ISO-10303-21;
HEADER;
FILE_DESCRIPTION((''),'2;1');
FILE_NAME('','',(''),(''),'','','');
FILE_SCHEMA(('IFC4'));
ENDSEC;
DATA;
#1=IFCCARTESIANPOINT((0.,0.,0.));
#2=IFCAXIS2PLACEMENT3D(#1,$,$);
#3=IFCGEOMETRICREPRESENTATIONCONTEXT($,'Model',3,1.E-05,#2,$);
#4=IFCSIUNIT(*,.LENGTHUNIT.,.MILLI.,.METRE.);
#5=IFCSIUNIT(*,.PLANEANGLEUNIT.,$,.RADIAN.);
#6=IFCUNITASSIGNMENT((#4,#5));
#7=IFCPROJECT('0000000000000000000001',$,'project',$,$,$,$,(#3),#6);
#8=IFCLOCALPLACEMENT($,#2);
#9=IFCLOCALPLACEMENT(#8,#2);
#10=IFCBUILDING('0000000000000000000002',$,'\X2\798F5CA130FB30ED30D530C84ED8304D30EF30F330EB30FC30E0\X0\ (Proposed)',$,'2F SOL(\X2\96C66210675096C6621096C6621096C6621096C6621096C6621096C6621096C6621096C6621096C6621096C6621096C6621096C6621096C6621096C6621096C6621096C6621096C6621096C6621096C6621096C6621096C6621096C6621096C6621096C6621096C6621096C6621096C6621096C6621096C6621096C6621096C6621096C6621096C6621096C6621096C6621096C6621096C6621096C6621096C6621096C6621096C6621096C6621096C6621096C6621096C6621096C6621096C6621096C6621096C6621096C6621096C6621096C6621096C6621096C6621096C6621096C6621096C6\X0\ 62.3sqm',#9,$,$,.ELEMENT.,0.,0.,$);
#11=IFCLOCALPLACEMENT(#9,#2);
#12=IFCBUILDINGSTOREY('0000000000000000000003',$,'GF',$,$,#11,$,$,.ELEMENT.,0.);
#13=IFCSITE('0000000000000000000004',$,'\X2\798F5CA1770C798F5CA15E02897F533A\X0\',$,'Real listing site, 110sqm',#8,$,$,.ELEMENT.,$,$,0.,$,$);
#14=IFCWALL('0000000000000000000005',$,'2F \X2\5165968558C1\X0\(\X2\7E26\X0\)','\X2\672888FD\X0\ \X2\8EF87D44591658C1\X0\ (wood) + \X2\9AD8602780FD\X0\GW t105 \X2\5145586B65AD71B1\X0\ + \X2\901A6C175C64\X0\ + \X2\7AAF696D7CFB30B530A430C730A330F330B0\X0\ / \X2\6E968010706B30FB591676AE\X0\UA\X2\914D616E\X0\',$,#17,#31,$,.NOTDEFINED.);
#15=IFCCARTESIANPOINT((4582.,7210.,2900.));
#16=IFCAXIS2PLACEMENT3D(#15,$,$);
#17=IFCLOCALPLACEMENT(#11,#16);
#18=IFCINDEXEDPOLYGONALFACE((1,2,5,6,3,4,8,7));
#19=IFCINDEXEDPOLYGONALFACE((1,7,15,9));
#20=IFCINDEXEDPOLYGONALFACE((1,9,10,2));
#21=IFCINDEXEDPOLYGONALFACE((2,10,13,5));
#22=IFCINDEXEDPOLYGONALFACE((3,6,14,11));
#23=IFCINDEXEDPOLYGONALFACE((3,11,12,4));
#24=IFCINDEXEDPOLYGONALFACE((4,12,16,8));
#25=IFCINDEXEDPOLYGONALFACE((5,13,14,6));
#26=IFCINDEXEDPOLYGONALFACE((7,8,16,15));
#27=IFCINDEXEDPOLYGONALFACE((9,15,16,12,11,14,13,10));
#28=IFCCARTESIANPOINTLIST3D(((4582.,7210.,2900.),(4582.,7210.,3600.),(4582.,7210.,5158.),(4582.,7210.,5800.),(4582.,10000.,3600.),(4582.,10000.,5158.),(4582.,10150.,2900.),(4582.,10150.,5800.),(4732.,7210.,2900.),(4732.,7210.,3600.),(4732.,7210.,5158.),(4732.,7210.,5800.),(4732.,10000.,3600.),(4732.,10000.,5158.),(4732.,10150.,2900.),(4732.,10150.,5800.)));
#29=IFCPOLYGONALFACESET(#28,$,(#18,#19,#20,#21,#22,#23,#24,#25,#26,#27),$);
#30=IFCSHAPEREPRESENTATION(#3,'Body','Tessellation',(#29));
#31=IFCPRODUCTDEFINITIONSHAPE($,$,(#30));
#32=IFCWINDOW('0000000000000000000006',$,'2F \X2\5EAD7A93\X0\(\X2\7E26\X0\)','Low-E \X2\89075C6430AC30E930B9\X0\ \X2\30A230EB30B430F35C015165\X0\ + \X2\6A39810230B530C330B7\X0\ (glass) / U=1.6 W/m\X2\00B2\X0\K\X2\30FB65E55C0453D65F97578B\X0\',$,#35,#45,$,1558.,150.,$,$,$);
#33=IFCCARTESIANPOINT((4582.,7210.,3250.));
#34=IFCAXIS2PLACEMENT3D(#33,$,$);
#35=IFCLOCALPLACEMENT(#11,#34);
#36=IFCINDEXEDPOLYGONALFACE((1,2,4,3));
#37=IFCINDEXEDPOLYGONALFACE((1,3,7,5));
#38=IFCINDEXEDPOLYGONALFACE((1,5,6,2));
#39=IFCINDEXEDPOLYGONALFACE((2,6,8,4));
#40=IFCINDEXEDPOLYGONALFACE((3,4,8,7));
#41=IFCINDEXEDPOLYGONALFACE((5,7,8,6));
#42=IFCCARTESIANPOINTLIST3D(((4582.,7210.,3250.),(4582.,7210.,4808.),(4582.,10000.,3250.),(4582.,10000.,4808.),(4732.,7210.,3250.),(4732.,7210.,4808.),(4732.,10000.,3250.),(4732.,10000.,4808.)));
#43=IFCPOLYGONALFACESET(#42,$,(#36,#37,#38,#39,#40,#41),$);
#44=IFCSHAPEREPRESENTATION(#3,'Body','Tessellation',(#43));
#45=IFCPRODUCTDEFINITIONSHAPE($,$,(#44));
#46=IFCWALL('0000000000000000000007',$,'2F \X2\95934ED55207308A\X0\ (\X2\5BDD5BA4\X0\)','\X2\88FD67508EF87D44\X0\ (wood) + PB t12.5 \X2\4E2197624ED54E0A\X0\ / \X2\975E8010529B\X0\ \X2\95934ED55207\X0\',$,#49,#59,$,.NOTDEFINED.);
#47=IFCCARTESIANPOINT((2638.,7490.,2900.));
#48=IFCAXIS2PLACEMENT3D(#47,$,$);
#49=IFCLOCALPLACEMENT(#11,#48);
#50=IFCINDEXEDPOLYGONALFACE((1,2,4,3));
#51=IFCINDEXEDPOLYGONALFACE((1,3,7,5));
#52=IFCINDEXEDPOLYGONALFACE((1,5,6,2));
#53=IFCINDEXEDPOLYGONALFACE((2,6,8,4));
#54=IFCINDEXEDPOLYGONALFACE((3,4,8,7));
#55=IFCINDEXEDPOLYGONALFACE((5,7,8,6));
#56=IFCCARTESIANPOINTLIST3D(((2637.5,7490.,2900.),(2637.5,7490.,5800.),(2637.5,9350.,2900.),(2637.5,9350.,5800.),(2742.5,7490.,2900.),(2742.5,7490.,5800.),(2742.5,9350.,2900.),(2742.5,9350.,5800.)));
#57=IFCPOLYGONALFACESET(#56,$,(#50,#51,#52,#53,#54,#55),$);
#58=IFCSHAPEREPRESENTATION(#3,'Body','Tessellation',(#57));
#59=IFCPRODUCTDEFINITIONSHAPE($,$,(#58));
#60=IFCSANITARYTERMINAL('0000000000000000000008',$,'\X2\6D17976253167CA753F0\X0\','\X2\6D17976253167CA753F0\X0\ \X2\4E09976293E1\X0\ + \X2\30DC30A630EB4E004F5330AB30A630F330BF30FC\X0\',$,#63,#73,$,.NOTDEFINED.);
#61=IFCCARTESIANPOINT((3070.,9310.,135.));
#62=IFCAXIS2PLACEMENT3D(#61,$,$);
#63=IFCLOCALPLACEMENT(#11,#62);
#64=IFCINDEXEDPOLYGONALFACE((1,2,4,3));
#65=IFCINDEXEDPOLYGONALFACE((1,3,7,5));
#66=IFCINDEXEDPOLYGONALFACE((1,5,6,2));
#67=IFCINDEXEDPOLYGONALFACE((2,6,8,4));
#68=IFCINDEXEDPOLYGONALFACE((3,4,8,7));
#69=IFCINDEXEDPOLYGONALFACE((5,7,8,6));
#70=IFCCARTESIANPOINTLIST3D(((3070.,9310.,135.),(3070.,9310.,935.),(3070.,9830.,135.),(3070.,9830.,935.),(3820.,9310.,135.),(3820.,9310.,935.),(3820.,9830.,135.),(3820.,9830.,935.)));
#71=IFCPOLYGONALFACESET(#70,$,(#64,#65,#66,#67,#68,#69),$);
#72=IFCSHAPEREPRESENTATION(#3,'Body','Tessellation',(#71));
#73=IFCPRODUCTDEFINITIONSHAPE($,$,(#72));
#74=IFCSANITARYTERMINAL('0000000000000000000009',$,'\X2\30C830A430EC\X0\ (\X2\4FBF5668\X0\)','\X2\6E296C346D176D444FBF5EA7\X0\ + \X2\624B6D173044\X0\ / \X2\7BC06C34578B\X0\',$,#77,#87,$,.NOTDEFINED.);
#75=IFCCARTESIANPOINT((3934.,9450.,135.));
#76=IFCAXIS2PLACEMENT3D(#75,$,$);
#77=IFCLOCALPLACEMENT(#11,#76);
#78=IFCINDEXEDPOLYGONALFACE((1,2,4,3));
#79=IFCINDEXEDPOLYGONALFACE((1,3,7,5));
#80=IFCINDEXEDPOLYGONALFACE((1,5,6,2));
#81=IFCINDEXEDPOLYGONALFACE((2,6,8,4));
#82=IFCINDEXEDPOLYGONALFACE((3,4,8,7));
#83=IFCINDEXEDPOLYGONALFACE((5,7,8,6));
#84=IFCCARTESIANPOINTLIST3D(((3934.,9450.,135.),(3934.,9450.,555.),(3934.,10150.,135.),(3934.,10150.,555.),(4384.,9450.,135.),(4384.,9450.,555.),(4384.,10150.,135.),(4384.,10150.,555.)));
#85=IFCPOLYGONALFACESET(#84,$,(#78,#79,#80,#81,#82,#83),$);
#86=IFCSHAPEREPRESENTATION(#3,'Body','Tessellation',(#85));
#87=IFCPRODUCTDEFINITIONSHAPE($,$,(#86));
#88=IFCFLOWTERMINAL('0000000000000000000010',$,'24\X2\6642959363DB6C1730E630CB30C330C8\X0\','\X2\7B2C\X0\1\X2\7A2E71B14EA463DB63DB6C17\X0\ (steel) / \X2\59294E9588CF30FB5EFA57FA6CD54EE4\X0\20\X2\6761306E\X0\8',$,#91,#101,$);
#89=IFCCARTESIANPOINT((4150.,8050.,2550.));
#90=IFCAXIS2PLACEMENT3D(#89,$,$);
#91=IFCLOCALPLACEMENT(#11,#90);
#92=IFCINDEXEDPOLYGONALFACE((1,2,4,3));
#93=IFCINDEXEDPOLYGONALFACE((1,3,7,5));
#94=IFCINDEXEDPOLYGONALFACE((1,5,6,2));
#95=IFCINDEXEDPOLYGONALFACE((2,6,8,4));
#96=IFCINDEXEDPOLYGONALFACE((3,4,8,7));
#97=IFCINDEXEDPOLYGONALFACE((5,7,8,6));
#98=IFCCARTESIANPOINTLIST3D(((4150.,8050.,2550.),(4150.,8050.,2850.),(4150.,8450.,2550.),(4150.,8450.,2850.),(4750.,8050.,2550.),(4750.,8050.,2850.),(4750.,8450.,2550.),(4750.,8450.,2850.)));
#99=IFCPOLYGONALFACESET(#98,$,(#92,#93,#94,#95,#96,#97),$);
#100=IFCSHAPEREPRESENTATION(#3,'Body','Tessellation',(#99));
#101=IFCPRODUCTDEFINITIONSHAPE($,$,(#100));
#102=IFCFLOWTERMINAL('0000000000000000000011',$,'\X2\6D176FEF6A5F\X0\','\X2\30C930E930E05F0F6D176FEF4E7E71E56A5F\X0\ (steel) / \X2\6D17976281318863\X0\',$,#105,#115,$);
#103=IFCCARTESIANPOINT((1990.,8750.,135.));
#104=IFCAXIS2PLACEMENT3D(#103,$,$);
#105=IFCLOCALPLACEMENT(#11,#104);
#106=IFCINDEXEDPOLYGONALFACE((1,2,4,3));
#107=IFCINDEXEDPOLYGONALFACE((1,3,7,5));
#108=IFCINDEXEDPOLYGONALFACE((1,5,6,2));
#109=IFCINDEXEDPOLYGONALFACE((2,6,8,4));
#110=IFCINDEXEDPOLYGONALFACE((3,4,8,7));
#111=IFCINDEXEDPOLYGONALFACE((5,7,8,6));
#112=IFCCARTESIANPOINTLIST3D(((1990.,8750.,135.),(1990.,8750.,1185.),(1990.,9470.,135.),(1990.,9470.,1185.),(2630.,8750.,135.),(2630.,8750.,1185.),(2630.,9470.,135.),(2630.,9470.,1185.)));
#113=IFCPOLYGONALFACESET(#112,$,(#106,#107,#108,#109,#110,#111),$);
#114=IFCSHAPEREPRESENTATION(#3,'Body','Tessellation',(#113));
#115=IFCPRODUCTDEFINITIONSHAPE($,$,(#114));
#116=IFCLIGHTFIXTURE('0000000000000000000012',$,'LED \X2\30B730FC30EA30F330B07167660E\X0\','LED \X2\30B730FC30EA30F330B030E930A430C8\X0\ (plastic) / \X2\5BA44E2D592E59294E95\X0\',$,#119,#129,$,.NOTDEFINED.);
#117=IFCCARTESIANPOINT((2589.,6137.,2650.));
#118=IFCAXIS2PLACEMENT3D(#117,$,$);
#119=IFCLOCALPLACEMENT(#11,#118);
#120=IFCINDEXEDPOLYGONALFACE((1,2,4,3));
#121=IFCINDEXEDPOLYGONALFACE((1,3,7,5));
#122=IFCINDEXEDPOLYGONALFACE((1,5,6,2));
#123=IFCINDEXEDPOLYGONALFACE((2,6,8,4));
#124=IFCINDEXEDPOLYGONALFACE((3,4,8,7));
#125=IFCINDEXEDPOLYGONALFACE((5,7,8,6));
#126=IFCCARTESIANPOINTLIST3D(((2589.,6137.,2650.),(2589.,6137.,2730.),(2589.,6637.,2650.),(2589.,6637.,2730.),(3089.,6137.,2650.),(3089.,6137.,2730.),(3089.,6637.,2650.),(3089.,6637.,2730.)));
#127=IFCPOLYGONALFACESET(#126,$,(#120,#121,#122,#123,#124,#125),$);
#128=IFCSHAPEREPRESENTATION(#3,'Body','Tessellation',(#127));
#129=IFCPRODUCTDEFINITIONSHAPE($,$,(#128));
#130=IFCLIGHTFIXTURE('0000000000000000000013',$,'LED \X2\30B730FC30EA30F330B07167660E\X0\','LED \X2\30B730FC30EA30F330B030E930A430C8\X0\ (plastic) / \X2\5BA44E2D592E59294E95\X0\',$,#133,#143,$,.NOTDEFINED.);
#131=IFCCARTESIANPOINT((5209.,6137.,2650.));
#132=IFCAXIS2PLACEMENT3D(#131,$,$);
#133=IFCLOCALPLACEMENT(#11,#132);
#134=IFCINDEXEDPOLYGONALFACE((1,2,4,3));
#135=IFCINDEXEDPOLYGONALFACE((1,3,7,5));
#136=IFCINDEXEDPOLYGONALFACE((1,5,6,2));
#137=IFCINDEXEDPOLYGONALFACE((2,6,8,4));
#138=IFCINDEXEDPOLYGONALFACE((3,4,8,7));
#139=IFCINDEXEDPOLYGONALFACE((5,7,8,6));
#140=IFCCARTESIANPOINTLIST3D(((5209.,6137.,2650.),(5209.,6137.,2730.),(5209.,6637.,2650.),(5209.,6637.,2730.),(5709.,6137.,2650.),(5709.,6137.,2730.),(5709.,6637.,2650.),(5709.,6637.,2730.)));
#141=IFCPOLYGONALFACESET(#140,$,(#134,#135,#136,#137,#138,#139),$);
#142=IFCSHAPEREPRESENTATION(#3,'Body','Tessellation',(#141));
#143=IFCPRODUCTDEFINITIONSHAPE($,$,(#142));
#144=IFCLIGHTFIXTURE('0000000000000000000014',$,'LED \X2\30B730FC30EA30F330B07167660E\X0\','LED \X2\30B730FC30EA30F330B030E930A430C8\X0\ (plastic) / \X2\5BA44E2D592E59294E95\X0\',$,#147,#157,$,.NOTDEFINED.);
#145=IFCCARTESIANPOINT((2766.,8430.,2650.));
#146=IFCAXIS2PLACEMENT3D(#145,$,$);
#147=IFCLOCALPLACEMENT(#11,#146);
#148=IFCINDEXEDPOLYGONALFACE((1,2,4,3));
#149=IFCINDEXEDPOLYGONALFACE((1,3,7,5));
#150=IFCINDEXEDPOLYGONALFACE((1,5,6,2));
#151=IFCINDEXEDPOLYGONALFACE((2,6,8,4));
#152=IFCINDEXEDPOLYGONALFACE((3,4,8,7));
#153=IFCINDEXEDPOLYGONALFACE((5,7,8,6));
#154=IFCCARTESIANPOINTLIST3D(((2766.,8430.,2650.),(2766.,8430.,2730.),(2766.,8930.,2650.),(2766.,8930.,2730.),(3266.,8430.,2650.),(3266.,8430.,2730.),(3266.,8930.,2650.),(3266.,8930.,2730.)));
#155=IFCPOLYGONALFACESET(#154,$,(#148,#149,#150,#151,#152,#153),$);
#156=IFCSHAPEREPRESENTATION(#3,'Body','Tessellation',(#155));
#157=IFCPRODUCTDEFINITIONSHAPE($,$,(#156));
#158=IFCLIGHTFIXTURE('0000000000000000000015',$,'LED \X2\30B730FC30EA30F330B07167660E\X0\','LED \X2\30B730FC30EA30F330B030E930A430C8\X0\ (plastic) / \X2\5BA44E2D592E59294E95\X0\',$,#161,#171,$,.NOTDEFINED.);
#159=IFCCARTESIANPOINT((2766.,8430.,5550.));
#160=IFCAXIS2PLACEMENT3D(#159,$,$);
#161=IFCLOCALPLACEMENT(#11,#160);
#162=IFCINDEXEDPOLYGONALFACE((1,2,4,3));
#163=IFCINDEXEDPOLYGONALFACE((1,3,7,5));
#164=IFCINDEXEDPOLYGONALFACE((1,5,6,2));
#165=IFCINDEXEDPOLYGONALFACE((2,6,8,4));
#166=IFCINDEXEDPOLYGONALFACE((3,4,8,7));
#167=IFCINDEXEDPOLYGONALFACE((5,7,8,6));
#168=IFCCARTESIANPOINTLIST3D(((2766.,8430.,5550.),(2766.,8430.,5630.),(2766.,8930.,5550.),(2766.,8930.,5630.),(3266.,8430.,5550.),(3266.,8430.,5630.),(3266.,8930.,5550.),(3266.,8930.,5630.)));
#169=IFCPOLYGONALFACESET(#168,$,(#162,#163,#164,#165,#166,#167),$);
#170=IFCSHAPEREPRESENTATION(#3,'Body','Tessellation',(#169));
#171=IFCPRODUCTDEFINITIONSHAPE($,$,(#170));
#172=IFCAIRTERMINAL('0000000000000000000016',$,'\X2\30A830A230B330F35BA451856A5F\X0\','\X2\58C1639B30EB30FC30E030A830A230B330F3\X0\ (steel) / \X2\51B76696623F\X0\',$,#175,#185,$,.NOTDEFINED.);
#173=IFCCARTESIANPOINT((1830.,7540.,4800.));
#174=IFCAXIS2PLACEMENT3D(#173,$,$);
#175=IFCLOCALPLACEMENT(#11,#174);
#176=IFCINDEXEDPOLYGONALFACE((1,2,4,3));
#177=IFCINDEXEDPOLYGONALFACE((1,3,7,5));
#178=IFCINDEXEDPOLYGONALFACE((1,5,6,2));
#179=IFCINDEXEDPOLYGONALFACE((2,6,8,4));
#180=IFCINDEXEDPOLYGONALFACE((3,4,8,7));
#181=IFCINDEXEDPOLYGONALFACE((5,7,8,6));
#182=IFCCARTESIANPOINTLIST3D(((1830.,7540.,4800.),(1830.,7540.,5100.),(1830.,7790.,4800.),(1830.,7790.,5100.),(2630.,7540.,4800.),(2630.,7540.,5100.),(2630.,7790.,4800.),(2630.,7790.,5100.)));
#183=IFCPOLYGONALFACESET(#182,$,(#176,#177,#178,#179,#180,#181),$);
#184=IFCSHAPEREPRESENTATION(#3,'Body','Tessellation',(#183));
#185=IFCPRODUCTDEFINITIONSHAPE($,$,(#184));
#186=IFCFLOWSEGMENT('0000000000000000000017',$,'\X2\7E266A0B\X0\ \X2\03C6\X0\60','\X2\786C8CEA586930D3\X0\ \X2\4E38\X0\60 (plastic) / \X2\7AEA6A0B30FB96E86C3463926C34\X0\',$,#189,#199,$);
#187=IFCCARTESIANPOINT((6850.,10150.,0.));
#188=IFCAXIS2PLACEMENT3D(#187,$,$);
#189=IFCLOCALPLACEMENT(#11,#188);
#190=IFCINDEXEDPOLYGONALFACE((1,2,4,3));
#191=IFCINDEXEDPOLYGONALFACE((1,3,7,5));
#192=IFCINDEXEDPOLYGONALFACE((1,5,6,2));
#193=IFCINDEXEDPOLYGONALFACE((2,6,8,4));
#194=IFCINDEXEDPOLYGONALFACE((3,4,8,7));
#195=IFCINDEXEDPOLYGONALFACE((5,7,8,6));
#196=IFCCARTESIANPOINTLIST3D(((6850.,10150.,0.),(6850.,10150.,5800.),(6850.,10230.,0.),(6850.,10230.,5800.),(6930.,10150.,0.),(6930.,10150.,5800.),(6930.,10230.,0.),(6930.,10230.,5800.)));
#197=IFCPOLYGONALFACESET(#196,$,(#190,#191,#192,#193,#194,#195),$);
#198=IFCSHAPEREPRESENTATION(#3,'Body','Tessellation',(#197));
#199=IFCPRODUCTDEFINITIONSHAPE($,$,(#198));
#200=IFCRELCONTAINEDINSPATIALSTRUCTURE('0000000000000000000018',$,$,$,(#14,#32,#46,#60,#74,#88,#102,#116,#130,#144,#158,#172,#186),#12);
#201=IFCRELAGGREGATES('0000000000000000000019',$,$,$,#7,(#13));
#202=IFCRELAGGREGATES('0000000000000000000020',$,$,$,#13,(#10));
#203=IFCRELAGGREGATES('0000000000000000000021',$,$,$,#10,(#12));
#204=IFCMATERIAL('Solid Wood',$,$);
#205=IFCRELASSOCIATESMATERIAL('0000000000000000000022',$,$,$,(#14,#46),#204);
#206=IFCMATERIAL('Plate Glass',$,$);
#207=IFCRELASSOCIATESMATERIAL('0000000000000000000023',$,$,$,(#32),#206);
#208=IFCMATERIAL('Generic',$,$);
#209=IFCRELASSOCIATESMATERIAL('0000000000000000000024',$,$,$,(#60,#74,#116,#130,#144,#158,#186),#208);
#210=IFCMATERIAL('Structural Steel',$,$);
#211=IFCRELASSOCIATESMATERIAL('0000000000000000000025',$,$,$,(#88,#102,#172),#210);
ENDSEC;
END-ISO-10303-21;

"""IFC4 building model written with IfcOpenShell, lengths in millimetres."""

from ifc_helpers import new_model, si_unit, frame, frame_2d, origin, place, context, project, spatial, rectangle, extrude, material, element, fill, save


model = new_model("IFC4")

# Units and contexts
model_context = context("Model", 3, precision=1e-05, world=origin())
ifc_project = project(units=[si_unit("LENGTHUNIT", "METRE", prefix="MILLI"), si_unit("PLANEANGLEUNIT", "RADIAN")], contexts=[model_context])

# Site, building, storey
site_placement = place(None, origin())
site = spatial("IfcSite", under=ifc_project, at=site_placement, Name="福岡県福岡市西区", ObjectType="Real listing site, 110sqm", CompositionType="ELEMENT", RefElevation=0.0)
building_placement = place(site_placement, origin())
building = spatial("IfcBuilding", under=site, at=building_placement, Name="福岡・ロフト付きワンルーム (Proposed)", ObjectType="2F SOL(集成材集成集成集成集成集成集成集成集成集成集成集成集成集成集成集成集成集成集成集成集成集成集成集成集成集成集成集成集成集成集成集成集成集成集成集成集成集成集成集成集成集成集成集成集成集成集成集成集成集成集成集成集成集成集成集成集成集 62.3sqm", CompositionType="ELEMENT", ElevationOfRefHeight=0.0, ElevationOfTerrain=0.0)
storey_placement = place(building_placement, origin())
storey = spatial("IfcBuildingStorey", under=building, at=storey_placement, Name="GF", CompositionType="ELEMENT", Elevation=0.0)

# Shared definitions
ifc_material_1 = material(Name="Solid Wood")

# Shared definitions
ifc_material_2 = material(Name="Plate Glass")

# Wall, opening, window
wall_1_placement = place(storey_placement, frame((4582.0, 7210.0, 2900.0)))
wall_1 = element("IfcWall", 1, at=wall_1_placement, inside=storey, material=ifc_material_1, Name="2F 入隅壁(縦)", Description="木製 軸組外壁 (wood) + 高性能GW t105 充填断熱 + 通気層 + 窯業系サイディング / 準耐火・外皮UA配慮", PredefinedType="NOTDEFINED", context=model_context, shape_type="SweptSolid", body=[
    extrude(rectangle(XDim=150.0, YDim=2940.0, at=frame_2d((75.0, 1470.0))), frame((4582.0, 7210.0, 2900.0)), (0.0, 0.0, 1.0), 2900.0),
])
opening_1_placement = place(storey_placement, frame((4582.0, 7210.0, 3250.0)))
opening_1 = element("IfcOpeningElement", 2, at=opening_1_placement, cuts=wall_1, PredefinedType="NOTDEFINED", context=model_context, shape_type="SweptSolid", body=[
    extrude(rectangle(XDim=150.0, YDim=2790.0, at=frame_2d((75.0, 1395.0))), frame((4582.0, 7210.0, 3250.0)), (0.0, 0.0, 1.0), 1558.0),
])
window_1_placement = place(storey_placement, frame((4582.0, 7210.0, 3250.0)))
window_1 = element("IfcWindow", 3, at=window_1_placement, inside=storey, material=ifc_material_2, Name="2F 庭窓(縦)", Description="Low-E 複層ガラス アルゴン封入 + 樹脂サッシ (glass) / U=1.6 W/m²K・日射取得型", OverallHeight=1558.0, OverallWidth=150.0, context=model_context, shape_type="SweptSolid", body=[
    extrude(rectangle(XDim=150.0, YDim=2790.0, at=frame_2d((75.0, 1395.0))), frame((4582.0, 7210.0, 3250.0)), (0.0, 0.0, 1.0), 1558.0),
])
fill(opening_1, window_1)

# Wall
wall_2_placement = place(storey_placement, frame((2638.0, 7490.0, 2900.0)))
element("IfcWall", 4, at=wall_2_placement, inside=storey, material=ifc_material_1, Name="2F 間仕切り (寝室)", Description="製材軸組 (wood) + PB t12.5 両面仕上 / 非耐力 間仕切", PredefinedType="NOTDEFINED", context=model_context, shape_type="SweptSolid", body=[
    extrude(rectangle(XDim=105.0, YDim=1860.0, at=frame_2d((52.0, 930.0))), frame((2638.0, 7490.0, 2900.0)), (0.0, 0.0, 1.0), 2900.0),
])

# Sanitary terminals
ifc_material_3 = material(Name="Generic")
sanitary_terminal_1_placement = place(storey_placement, frame((3070.0, 9310.0, 135.0)))
element("IfcSanitaryTerminal", 5, at=sanitary_terminal_1_placement, inside=storey, material=ifc_material_3, Name="洗面化粧台", Description="洗面化粧台 三面鏡 + ボウル一体カウンター", PredefinedType="NOTDEFINED", context=model_context, shape_type="SweptSolid", body=[
    extrude(rectangle(XDim=750.0, YDim=520.0, at=frame_2d((375.0, 260.0))), frame((3070.0, 9310.0, 135.0)), (0.0, 0.0, 1.0), 800.0),
])
sanitary_terminal_2_placement = place(storey_placement, frame((3934.0, 9450.0, 135.0)))
element("IfcSanitaryTerminal", 6, at=sanitary_terminal_2_placement, inside=storey, material=ifc_material_3, Name="トイレ (便器)", Description="温水洗浄便座 + 手洗い / 節水型", PredefinedType="NOTDEFINED", context=model_context, shape_type="SweptSolid", body=[
    extrude(rectangle(XDim=450.0, YDim=700.0, at=frame_2d((225.0, 350.0))), frame((3934.0, 9450.0, 135.0)), (0.0, 0.0, 1.0), 420.0),
])

# Flow terminals
ifc_material_4 = material(Name="Structural Steel")
flow_terminal_1_placement = place(storey_placement, frame((4150.0, 8050.0, 2550.0)))
element("IfcFlowTerminal", 7, at=flow_terminal_1_placement, inside=storey, material=ifc_material_4, Name="24時間換気ユニット", Description="第1種熱交換換気 (steel) / 天井裏・建基法令20条の8", context=model_context, shape_type="SweptSolid", body=[
    extrude(rectangle(XDim=600.0, YDim=400.0, at=frame_2d((300.0, 200.0))), frame((4150.0, 8050.0, 2550.0)), (0.0, 0.0, 1.0), 300.0),
])
flow_terminal_2_placement = place(storey_placement, frame((1990.0, 8750.0, 135.0)))
element("IfcFlowTerminal", 8, at=flow_terminal_2_placement, inside=storey, material=ifc_material_4, Name="洗濯機", Description="ドラム式洗濯乾燥機 (steel) / 洗面脱衣", context=model_context, shape_type="SweptSolid", body=[
    extrude(rectangle(XDim=640.0, YDim=720.0, at=frame_2d((320.0, 360.0))), frame((1990.0, 8750.0, 135.0)), (0.0, 0.0, 1.0), 1050.0),
])

# Light fixtures
light_fixture_1_placement = place(storey_placement, frame((2589.0, 6137.0, 2650.0)))
element("IfcLightFixture", 9, at=light_fixture_1_placement, inside=storey, material=ifc_material_3, Name="LED シーリング照明", Description="LED シーリングライト (plastic) / 室中央天井", PredefinedType="NOTDEFINED", context=model_context, shape_type="SweptSolid", body=[
    extrude(rectangle(XDim=500.0, YDim=500.0, at=frame_2d((250.0, 250.0))), frame((2589.0, 6137.0, 2650.0)), (0.0, 0.0, 1.0), 80.0),
])
light_fixture_2_placement = place(storey_placement, frame((5209.0, 6137.0, 2650.0)))
element("IfcLightFixture", 10, at=light_fixture_2_placement, inside=storey, material=ifc_material_3, Name="LED シーリング照明", Description="LED シーリングライト (plastic) / 室中央天井", PredefinedType="NOTDEFINED", context=model_context, shape_type="SweptSolid", body=[
    extrude(rectangle(XDim=500.0, YDim=500.0, at=frame_2d((250.0, 250.0))), frame((5209.0, 6137.0, 2650.0)), (0.0, 0.0, 1.0), 80.0),
])
light_fixture_3_placement = place(storey_placement, frame((2766.0, 8430.0, 2650.0)))
element("IfcLightFixture", 11, at=light_fixture_3_placement, inside=storey, material=ifc_material_3, Name="LED シーリング照明", Description="LED シーリングライト (plastic) / 室中央天井", PredefinedType="NOTDEFINED", context=model_context, shape_type="SweptSolid", body=[
    extrude(rectangle(XDim=500.0, YDim=500.0, at=frame_2d((250.0, 250.0))), frame((2766.0, 8430.0, 2650.0)), (0.0, 0.0, 1.0), 80.0),
])
light_fixture_4_placement = place(storey_placement, frame((2766.0, 8430.0, 5550.0)))
element("IfcLightFixture", 12, at=light_fixture_4_placement, inside=storey, material=ifc_material_3, Name="LED シーリング照明", Description="LED シーリングライト (plastic) / 室中央天井", PredefinedType="NOTDEFINED", context=model_context, shape_type="SweptSolid", body=[
    extrude(rectangle(XDim=500.0, YDim=500.0, at=frame_2d((250.0, 250.0))), frame((2766.0, 8430.0, 5550.0)), (0.0, 0.0, 1.0), 80.0),
])

# Air terminal
air_terminal_placement = place(storey_placement, frame((1830.0, 7540.0, 4800.0)))
element("IfcAirTerminal", 13, at=air_terminal_placement, inside=storey, material=ifc_material_4, Name="エアコン室内機", Description="壁掛ルームエアコン (steel) / 冷暖房", PredefinedType="NOTDEFINED", context=model_context, shape_type="SweptSolid", body=[
    extrude(rectangle(XDim=800.0, YDim=250.0, at=frame_2d((400.0, 125.0))), frame((1830.0, 7540.0, 4800.0)), (0.0, 0.0, 1.0), 300.0),
])

# Flow segment
flow_segment_placement = place(storey_placement, frame((6850.0, 10150.0, 0.0)))
element("IfcFlowSegment", 14, at=flow_segment_placement, inside=storey, material=ifc_material_3, Name="縦樋 φ60", Description="硬質塩ビ 丸60 (plastic) / 竪樋・雨水排水", context=model_context, shape_type="SweptSolid", body=[
    extrude(rectangle(XDim=80.0, YDim=80.0, at=frame_2d((40.0, 40.0))), frame((6850.0, 10150.0, 0.0)), (0.0, 0.0, 1.0), 5800.0),
])

save(model, "model.ifc")
